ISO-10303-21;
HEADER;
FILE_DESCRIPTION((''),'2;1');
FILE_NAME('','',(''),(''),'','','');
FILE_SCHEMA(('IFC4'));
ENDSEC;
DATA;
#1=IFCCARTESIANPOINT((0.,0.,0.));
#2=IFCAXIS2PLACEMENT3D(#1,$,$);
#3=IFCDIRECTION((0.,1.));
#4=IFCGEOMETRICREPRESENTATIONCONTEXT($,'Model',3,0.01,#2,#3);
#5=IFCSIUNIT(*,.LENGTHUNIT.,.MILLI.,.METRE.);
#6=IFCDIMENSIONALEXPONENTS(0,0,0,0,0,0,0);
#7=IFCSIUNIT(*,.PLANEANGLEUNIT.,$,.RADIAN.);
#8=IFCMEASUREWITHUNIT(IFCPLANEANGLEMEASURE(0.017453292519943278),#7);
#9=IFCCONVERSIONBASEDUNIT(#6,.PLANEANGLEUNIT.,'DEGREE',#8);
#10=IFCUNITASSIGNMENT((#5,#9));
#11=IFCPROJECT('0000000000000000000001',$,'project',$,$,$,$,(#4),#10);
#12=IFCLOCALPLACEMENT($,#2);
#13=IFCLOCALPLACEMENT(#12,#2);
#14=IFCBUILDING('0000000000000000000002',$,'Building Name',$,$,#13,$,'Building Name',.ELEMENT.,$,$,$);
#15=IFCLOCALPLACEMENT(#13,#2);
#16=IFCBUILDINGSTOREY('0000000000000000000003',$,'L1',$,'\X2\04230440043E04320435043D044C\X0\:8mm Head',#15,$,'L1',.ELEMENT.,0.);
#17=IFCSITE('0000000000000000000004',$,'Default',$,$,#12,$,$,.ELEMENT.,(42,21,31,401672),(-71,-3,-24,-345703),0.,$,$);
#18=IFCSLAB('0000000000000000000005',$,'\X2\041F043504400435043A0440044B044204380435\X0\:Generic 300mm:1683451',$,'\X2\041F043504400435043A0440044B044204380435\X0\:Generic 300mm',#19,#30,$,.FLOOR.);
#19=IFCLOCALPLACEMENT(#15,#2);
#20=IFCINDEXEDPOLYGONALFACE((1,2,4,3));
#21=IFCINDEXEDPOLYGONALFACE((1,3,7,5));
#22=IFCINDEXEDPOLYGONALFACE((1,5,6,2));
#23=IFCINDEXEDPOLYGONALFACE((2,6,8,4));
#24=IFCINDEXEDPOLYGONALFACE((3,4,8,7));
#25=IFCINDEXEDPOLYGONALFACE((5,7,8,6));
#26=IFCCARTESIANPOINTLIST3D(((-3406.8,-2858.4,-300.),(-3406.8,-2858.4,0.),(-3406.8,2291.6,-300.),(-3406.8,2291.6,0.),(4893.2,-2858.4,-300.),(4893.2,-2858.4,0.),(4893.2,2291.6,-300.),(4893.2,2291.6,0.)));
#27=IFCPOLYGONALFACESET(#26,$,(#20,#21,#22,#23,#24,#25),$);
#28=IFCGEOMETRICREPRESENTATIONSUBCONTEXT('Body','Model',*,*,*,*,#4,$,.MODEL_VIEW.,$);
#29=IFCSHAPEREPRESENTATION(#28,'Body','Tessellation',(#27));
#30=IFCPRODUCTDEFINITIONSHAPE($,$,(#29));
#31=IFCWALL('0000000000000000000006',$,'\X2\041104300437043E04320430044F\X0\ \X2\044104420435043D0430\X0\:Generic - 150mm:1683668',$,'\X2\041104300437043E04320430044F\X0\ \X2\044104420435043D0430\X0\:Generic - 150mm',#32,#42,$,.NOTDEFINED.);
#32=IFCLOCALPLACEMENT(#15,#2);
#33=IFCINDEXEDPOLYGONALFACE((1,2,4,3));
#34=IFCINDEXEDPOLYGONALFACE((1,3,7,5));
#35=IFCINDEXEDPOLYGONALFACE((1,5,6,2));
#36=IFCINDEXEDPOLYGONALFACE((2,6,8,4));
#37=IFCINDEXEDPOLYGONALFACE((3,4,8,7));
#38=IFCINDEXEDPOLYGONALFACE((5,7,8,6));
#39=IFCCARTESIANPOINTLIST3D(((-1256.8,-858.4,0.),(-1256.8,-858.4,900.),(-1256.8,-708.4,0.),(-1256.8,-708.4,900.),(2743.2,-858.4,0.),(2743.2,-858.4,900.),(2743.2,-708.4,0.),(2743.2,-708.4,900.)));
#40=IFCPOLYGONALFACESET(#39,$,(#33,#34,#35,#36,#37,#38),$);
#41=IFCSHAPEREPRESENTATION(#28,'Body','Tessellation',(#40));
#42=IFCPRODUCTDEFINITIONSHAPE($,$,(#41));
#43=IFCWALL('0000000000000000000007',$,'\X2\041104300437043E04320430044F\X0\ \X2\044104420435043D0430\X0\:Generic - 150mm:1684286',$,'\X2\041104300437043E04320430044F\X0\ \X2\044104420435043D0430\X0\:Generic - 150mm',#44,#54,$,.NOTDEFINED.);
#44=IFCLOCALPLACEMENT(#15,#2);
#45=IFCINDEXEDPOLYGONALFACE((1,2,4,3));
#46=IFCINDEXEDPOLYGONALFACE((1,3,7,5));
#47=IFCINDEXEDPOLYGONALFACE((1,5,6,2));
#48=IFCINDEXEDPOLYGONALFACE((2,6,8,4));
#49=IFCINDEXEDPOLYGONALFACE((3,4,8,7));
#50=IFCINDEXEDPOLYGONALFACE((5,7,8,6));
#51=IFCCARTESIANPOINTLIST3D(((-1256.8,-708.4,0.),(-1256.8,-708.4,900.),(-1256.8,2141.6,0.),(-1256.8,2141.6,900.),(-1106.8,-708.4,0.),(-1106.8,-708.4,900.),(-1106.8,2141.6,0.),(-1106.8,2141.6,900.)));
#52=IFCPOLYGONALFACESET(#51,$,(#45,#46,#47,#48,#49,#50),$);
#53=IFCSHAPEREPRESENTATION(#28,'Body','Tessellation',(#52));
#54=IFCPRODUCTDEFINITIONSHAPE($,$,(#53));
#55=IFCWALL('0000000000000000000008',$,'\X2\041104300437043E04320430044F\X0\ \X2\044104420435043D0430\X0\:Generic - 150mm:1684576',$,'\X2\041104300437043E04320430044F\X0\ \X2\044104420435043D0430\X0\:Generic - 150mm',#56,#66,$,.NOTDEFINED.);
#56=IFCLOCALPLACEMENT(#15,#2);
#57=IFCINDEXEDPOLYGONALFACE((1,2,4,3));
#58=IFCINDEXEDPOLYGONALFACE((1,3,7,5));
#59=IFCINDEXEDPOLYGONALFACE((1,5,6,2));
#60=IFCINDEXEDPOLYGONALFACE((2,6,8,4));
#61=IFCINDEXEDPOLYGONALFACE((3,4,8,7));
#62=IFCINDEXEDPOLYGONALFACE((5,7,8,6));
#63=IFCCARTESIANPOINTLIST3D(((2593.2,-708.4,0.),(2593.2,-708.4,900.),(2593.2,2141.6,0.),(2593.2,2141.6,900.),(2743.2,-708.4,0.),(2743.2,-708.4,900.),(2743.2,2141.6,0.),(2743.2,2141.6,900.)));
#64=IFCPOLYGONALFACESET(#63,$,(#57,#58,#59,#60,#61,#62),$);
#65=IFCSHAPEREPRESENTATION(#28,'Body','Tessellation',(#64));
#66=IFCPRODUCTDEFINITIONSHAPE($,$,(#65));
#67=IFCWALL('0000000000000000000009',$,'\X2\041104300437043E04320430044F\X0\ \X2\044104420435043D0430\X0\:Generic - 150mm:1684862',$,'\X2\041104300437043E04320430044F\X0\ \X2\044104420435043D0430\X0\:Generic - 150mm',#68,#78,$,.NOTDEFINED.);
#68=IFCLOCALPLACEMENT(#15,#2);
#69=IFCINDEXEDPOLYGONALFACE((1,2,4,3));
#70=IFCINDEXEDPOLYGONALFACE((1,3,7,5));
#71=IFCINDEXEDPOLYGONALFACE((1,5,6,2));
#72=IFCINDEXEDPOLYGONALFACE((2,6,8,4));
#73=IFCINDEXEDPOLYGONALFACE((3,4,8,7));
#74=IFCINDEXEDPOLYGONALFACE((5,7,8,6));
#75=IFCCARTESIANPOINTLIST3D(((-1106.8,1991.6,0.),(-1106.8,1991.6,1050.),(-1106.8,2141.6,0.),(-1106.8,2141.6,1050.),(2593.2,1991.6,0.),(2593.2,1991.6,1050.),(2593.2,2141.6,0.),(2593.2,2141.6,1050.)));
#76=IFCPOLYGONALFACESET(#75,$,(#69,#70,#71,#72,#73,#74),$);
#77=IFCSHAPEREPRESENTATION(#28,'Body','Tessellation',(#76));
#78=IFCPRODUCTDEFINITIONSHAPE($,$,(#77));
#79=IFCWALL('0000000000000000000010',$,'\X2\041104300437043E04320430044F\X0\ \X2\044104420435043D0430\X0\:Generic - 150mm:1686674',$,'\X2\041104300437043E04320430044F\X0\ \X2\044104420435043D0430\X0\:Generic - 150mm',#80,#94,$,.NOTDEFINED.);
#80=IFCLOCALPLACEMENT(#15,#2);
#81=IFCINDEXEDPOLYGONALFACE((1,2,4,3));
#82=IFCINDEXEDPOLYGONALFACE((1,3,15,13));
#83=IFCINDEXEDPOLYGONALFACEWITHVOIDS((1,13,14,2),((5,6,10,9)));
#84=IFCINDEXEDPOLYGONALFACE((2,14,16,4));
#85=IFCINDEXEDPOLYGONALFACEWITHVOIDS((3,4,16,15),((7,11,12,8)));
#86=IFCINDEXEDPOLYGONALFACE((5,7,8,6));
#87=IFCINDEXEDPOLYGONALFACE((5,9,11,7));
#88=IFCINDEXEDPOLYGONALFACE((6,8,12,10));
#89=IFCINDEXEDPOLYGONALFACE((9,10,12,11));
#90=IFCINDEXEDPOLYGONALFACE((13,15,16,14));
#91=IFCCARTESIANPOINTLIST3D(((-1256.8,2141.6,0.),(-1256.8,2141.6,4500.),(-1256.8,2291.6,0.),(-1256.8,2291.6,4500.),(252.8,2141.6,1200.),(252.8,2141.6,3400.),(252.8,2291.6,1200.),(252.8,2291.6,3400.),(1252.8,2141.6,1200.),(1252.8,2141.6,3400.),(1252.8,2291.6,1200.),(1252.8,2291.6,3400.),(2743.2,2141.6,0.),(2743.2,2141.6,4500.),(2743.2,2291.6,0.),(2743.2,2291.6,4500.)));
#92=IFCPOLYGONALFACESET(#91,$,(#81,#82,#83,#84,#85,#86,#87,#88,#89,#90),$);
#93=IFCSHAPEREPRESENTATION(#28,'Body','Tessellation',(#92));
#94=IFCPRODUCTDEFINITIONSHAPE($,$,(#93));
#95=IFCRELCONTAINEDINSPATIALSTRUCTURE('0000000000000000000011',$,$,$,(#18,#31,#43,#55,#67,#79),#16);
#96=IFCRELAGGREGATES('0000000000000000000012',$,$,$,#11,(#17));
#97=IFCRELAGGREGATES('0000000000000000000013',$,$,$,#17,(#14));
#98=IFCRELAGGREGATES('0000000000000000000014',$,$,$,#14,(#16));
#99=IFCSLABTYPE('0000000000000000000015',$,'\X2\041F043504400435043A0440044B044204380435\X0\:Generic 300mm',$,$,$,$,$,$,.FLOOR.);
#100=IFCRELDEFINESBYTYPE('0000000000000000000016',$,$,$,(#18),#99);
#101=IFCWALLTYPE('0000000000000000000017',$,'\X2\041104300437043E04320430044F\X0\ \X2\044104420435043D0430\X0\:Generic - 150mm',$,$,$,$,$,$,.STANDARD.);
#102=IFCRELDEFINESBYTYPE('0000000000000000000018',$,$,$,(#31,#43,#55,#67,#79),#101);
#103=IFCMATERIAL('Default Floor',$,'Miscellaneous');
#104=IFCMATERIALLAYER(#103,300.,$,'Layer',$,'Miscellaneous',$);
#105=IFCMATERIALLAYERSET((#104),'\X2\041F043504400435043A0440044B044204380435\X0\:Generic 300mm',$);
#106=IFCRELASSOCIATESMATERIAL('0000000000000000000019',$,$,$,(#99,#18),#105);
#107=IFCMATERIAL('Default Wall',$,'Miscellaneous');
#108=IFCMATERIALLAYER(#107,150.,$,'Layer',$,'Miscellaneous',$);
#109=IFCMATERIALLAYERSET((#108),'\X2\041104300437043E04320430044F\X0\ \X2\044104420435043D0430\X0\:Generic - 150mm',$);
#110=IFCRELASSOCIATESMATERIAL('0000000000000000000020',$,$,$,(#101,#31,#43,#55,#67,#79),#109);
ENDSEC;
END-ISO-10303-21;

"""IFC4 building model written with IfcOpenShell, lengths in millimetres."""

from ifc_helpers import new_model, entity, si_unit, converted_unit, direction, frame, frame_2d, origin, origin_2d_with_axis, place, context, subcontext, project, spatial, polyline, rectangle, extrude, clip, bounded_halfspace, material, layer, layer_set, layer_usage, type_object, element, save


model = new_model("IFC4")

# Units and contexts
model_context = context("Model", 3, precision=0.01, world=origin(), true_north=direction((0.0, 1.0)))
body_context = subcontext(model_context, "Body", "Model", "MODEL_VIEW")
ifc_project = project(units=[si_unit("LENGTHUNIT", "METRE", prefix="MILLI"), converted_unit("PLANEANGLEUNIT", "DEGREE", entity("IfcPlaneAngleMeasure", 0.017453292519943278), si_unit("PLANEANGLEUNIT", "RADIAN"), dimensions=[0, 0, 0, 0, 0, 0, 0])], contexts=[model_context])

# Site, building, storey
site_placement = place(None, origin())
site = spatial("IfcSite", under=ifc_project, at=site_placement, Name="Default", CompositionType="ELEMENT", RefLatitude=(42, 21, 31, 401672), RefLongitude=(-71, -3, -24, -345703), RefElevation=0.0)
building_placement = place(site_placement, origin())
building = spatial("IfcBuilding", under=site, at=building_placement, Name="Building Name", LongName="Building Name", CompositionType="ELEMENT")
storey_placement = place(building_placement, origin())
storey = spatial("IfcBuildingStorey", under=building, at=storey_placement, Name="L1", ObjectType="Уровень:8mm Head", LongName="L1", CompositionType="ELEMENT", Elevation=0.0)

# Slab
ifc_material_1 = material(Name="Default Floor", Category="Miscellaneous")
ifc_layer_1 = layer(ifc_material_1, 300.0, Name="Layer", Category="Miscellaneous")
ifc_layer_set_1 = layer_set([ifc_layer_1], Name="Перекрытие:Generic 300mm")
ifc_layer_usage_1 = layer_usage(ifc_layer_set_1, "AXIS3", "POSITIVE", 0.0)
slab_type = type_object("IfcSlabType", Name="Перекрытие:Generic 300mm", PredefinedType="FLOOR", material=ifc_layer_set_1)
slab_placement = place(storey_placement, origin())
element("IfcSlab", 1, at=slab_placement, inside=storey, type_object=slab_type, material=ifc_layer_usage_1, Name="Перекрытие:Generic 300mm:1683451", ObjectType="Перекрытие:Generic 300mm", PredefinedType="FLOOR", context=body_context, shape_type="SweptSolid", body=[
    extrude(rectangle(XDim=5150.0, YDim=8300.0, at=origin_2d_with_axis()), frame((743.2, -283.4, 0.0), z_axis=(0.0, 0.0, -1.0), x_axis=(0.0, 1.0, 0.0)), (0.0, 0.0, 1.0), 300.0),
])

# Walls
ifc_material_2 = material(Name="Default Wall", Category="Miscellaneous")
ifc_layer_2 = layer(ifc_material_2, 150.0, Name="Layer", Category="Miscellaneous")
ifc_layer_set_2 = layer_set([ifc_layer_2], Name="Базовая стена:Generic - 150mm")
ifc_layer_usage_2 = layer_usage(ifc_layer_set_2, "AXIS2", "NEGATIVE", 75.0)
wall_type = type_object("IfcWallType", Name="Базовая стена:Generic - 150mm", PredefinedType="STANDARD", material=ifc_layer_set_2)
wall_1_placement = place(storey_placement, frame((-1256.8, -783.4, 0.0)))
element("IfcWall", 2, at=wall_1_placement, inside=storey, type_object=wall_type, material=ifc_layer_usage_2, Name="Базовая стена:Generic - 150mm:1683668", ObjectType="Базовая стена:Generic - 150mm", PredefinedType="NOTDEFINED", context=body_context, shape_type="Clipping", body=[
    clip(extrude(rectangle(XDim=4000.0, YDim=150.0, at=frame_2d((2000.0, 0.0), x_axis=(-1.0, 0.0))), origin(), (0.0, 0.0, 1.0), 900.0), bounded_halfspace(frame((0.0, -75.0, 900.0), z_axis=(0.0, 0.0, -1.0), x_axis=(-1.0, 0.0, 0.0)), True, frame((0.0, -75.0, 900.0)), polyline([(0.0, 0.0), (4000.0, 0.0), (4000.0, 150.0), (3850.0, 150.0), (150.0, 150.0), (0.0, 150.0), (0.0, 0.0)]))),
])
ifc_layer_usage_3 = layer_usage(ifc_layer_set_2, "AXIS2", "NEGATIVE", 75.0)
wall_2_placement = place(storey_placement, frame((-1181.8, -708.4, 0.0), z_axis=(0.0, 0.0, 1.0), x_axis=(0.0, 1.0, 0.0)))
element("IfcWall", 3, at=wall_2_placement, inside=storey, type_object=wall_type, material=ifc_layer_usage_3, Name="Базовая стена:Generic - 150mm:1684286", ObjectType="Базовая стена:Generic - 150mm", PredefinedType="NOTDEFINED", context=body_context, shape_type="SweptSolid", body=[
    extrude(rectangle(XDim=2850.0, YDim=150.0, at=frame_2d((1425.0, 0.0), x_axis=(-1.0, 0.0))), origin(), (0.0, 0.0, 1.0), 900.0),
])
ifc_layer_usage_4 = layer_usage(ifc_layer_set_2, "AXIS2", "NEGATIVE", 75.0)
wall_3_placement = place(storey_placement, frame((2668.2, -708.4, 0.0), z_axis=(0.0, 0.0, 1.0), x_axis=(0.0, 1.0, 0.0)))
element("IfcWall", 4, at=wall_3_placement, inside=storey, type_object=wall_type, material=ifc_layer_usage_4, Name="Базовая стена:Generic - 150mm:1684576", ObjectType="Базовая стена:Generic - 150mm", PredefinedType="NOTDEFINED", context=body_context, shape_type="SweptSolid", body=[
    extrude(rectangle(XDim=2850.0, YDim=150.0, at=frame_2d((1425.0, 0.0), x_axis=(-1.0, 0.0))), origin(), (0.0, 0.0, 1.0), 900.0),
])
ifc_layer_usage_5 = layer_usage(ifc_layer_set_2, "AXIS2", "NEGATIVE", 75.0)
wall_4_placement = place(storey_placement, frame((-1106.8, 2066.6, 0.0)))
element("IfcWall", 5, at=wall_4_placement, inside=storey, type_object=wall_type, material=ifc_layer_usage_5, Name="Базовая стена:Generic - 150mm:1684862", ObjectType="Базовая стена:Generic - 150mm", PredefinedType="NOTDEFINED", context=body_context, shape_type="SweptSolid", body=[
    extrude(rectangle(XDim=3700.0, YDim=150.0, at=frame_2d((1850.0, 0.0), x_axis=(-1.0, 0.0))), origin(), (0.0, 0.0, 1.0), 1050.0),
])

# Wall, opening
ifc_layer_usage_6 = layer_usage(ifc_layer_set_2, "AXIS2", "POSITIVE", -75.0)
wall_5_placement = place(storey_placement, frame((-1256.8, 2216.6, 0.0)))
wall_5 = element("IfcWall", 6, at=wall_5_placement, inside=storey, type_object=wall_type, material=ifc_layer_usage_6, Name="Базовая стена:Generic - 150mm:1686674", ObjectType="Базовая стена:Generic - 150mm", PredefinedType="NOTDEFINED", context=body_context, shape_type="SweptSolid", body=[
    extrude(rectangle(XDim=4000.0, YDim=150.0, at=frame_2d((2000.0, 0.0), x_axis=(-1.0, 0.0))), origin(), (0.0, 0.0, 1.0), 4500.0),
])
opening_placement = place(wall_5_placement, frame((2509.5, 75.0, 1200.0)))
element("IfcOpeningElement", 7, at=opening_placement, cuts=wall_5, PredefinedType="OPENING", context=body_context, shape_type="SweptSolid", body=[
    extrude(rectangle(XDim=2200.0, YDim=1000.0, at=frame_2d((1100.0, 500.0), x_axis=(1.0, 0.0))), frame((0.0, 0.0, 0.0), z_axis=(0.0, -1.0, 0.0), x_axis=(0.0, 0.0, 1.0)), (0.0, 0.0, 1.0), 150.0),
])

save(model, "model.ifc")
